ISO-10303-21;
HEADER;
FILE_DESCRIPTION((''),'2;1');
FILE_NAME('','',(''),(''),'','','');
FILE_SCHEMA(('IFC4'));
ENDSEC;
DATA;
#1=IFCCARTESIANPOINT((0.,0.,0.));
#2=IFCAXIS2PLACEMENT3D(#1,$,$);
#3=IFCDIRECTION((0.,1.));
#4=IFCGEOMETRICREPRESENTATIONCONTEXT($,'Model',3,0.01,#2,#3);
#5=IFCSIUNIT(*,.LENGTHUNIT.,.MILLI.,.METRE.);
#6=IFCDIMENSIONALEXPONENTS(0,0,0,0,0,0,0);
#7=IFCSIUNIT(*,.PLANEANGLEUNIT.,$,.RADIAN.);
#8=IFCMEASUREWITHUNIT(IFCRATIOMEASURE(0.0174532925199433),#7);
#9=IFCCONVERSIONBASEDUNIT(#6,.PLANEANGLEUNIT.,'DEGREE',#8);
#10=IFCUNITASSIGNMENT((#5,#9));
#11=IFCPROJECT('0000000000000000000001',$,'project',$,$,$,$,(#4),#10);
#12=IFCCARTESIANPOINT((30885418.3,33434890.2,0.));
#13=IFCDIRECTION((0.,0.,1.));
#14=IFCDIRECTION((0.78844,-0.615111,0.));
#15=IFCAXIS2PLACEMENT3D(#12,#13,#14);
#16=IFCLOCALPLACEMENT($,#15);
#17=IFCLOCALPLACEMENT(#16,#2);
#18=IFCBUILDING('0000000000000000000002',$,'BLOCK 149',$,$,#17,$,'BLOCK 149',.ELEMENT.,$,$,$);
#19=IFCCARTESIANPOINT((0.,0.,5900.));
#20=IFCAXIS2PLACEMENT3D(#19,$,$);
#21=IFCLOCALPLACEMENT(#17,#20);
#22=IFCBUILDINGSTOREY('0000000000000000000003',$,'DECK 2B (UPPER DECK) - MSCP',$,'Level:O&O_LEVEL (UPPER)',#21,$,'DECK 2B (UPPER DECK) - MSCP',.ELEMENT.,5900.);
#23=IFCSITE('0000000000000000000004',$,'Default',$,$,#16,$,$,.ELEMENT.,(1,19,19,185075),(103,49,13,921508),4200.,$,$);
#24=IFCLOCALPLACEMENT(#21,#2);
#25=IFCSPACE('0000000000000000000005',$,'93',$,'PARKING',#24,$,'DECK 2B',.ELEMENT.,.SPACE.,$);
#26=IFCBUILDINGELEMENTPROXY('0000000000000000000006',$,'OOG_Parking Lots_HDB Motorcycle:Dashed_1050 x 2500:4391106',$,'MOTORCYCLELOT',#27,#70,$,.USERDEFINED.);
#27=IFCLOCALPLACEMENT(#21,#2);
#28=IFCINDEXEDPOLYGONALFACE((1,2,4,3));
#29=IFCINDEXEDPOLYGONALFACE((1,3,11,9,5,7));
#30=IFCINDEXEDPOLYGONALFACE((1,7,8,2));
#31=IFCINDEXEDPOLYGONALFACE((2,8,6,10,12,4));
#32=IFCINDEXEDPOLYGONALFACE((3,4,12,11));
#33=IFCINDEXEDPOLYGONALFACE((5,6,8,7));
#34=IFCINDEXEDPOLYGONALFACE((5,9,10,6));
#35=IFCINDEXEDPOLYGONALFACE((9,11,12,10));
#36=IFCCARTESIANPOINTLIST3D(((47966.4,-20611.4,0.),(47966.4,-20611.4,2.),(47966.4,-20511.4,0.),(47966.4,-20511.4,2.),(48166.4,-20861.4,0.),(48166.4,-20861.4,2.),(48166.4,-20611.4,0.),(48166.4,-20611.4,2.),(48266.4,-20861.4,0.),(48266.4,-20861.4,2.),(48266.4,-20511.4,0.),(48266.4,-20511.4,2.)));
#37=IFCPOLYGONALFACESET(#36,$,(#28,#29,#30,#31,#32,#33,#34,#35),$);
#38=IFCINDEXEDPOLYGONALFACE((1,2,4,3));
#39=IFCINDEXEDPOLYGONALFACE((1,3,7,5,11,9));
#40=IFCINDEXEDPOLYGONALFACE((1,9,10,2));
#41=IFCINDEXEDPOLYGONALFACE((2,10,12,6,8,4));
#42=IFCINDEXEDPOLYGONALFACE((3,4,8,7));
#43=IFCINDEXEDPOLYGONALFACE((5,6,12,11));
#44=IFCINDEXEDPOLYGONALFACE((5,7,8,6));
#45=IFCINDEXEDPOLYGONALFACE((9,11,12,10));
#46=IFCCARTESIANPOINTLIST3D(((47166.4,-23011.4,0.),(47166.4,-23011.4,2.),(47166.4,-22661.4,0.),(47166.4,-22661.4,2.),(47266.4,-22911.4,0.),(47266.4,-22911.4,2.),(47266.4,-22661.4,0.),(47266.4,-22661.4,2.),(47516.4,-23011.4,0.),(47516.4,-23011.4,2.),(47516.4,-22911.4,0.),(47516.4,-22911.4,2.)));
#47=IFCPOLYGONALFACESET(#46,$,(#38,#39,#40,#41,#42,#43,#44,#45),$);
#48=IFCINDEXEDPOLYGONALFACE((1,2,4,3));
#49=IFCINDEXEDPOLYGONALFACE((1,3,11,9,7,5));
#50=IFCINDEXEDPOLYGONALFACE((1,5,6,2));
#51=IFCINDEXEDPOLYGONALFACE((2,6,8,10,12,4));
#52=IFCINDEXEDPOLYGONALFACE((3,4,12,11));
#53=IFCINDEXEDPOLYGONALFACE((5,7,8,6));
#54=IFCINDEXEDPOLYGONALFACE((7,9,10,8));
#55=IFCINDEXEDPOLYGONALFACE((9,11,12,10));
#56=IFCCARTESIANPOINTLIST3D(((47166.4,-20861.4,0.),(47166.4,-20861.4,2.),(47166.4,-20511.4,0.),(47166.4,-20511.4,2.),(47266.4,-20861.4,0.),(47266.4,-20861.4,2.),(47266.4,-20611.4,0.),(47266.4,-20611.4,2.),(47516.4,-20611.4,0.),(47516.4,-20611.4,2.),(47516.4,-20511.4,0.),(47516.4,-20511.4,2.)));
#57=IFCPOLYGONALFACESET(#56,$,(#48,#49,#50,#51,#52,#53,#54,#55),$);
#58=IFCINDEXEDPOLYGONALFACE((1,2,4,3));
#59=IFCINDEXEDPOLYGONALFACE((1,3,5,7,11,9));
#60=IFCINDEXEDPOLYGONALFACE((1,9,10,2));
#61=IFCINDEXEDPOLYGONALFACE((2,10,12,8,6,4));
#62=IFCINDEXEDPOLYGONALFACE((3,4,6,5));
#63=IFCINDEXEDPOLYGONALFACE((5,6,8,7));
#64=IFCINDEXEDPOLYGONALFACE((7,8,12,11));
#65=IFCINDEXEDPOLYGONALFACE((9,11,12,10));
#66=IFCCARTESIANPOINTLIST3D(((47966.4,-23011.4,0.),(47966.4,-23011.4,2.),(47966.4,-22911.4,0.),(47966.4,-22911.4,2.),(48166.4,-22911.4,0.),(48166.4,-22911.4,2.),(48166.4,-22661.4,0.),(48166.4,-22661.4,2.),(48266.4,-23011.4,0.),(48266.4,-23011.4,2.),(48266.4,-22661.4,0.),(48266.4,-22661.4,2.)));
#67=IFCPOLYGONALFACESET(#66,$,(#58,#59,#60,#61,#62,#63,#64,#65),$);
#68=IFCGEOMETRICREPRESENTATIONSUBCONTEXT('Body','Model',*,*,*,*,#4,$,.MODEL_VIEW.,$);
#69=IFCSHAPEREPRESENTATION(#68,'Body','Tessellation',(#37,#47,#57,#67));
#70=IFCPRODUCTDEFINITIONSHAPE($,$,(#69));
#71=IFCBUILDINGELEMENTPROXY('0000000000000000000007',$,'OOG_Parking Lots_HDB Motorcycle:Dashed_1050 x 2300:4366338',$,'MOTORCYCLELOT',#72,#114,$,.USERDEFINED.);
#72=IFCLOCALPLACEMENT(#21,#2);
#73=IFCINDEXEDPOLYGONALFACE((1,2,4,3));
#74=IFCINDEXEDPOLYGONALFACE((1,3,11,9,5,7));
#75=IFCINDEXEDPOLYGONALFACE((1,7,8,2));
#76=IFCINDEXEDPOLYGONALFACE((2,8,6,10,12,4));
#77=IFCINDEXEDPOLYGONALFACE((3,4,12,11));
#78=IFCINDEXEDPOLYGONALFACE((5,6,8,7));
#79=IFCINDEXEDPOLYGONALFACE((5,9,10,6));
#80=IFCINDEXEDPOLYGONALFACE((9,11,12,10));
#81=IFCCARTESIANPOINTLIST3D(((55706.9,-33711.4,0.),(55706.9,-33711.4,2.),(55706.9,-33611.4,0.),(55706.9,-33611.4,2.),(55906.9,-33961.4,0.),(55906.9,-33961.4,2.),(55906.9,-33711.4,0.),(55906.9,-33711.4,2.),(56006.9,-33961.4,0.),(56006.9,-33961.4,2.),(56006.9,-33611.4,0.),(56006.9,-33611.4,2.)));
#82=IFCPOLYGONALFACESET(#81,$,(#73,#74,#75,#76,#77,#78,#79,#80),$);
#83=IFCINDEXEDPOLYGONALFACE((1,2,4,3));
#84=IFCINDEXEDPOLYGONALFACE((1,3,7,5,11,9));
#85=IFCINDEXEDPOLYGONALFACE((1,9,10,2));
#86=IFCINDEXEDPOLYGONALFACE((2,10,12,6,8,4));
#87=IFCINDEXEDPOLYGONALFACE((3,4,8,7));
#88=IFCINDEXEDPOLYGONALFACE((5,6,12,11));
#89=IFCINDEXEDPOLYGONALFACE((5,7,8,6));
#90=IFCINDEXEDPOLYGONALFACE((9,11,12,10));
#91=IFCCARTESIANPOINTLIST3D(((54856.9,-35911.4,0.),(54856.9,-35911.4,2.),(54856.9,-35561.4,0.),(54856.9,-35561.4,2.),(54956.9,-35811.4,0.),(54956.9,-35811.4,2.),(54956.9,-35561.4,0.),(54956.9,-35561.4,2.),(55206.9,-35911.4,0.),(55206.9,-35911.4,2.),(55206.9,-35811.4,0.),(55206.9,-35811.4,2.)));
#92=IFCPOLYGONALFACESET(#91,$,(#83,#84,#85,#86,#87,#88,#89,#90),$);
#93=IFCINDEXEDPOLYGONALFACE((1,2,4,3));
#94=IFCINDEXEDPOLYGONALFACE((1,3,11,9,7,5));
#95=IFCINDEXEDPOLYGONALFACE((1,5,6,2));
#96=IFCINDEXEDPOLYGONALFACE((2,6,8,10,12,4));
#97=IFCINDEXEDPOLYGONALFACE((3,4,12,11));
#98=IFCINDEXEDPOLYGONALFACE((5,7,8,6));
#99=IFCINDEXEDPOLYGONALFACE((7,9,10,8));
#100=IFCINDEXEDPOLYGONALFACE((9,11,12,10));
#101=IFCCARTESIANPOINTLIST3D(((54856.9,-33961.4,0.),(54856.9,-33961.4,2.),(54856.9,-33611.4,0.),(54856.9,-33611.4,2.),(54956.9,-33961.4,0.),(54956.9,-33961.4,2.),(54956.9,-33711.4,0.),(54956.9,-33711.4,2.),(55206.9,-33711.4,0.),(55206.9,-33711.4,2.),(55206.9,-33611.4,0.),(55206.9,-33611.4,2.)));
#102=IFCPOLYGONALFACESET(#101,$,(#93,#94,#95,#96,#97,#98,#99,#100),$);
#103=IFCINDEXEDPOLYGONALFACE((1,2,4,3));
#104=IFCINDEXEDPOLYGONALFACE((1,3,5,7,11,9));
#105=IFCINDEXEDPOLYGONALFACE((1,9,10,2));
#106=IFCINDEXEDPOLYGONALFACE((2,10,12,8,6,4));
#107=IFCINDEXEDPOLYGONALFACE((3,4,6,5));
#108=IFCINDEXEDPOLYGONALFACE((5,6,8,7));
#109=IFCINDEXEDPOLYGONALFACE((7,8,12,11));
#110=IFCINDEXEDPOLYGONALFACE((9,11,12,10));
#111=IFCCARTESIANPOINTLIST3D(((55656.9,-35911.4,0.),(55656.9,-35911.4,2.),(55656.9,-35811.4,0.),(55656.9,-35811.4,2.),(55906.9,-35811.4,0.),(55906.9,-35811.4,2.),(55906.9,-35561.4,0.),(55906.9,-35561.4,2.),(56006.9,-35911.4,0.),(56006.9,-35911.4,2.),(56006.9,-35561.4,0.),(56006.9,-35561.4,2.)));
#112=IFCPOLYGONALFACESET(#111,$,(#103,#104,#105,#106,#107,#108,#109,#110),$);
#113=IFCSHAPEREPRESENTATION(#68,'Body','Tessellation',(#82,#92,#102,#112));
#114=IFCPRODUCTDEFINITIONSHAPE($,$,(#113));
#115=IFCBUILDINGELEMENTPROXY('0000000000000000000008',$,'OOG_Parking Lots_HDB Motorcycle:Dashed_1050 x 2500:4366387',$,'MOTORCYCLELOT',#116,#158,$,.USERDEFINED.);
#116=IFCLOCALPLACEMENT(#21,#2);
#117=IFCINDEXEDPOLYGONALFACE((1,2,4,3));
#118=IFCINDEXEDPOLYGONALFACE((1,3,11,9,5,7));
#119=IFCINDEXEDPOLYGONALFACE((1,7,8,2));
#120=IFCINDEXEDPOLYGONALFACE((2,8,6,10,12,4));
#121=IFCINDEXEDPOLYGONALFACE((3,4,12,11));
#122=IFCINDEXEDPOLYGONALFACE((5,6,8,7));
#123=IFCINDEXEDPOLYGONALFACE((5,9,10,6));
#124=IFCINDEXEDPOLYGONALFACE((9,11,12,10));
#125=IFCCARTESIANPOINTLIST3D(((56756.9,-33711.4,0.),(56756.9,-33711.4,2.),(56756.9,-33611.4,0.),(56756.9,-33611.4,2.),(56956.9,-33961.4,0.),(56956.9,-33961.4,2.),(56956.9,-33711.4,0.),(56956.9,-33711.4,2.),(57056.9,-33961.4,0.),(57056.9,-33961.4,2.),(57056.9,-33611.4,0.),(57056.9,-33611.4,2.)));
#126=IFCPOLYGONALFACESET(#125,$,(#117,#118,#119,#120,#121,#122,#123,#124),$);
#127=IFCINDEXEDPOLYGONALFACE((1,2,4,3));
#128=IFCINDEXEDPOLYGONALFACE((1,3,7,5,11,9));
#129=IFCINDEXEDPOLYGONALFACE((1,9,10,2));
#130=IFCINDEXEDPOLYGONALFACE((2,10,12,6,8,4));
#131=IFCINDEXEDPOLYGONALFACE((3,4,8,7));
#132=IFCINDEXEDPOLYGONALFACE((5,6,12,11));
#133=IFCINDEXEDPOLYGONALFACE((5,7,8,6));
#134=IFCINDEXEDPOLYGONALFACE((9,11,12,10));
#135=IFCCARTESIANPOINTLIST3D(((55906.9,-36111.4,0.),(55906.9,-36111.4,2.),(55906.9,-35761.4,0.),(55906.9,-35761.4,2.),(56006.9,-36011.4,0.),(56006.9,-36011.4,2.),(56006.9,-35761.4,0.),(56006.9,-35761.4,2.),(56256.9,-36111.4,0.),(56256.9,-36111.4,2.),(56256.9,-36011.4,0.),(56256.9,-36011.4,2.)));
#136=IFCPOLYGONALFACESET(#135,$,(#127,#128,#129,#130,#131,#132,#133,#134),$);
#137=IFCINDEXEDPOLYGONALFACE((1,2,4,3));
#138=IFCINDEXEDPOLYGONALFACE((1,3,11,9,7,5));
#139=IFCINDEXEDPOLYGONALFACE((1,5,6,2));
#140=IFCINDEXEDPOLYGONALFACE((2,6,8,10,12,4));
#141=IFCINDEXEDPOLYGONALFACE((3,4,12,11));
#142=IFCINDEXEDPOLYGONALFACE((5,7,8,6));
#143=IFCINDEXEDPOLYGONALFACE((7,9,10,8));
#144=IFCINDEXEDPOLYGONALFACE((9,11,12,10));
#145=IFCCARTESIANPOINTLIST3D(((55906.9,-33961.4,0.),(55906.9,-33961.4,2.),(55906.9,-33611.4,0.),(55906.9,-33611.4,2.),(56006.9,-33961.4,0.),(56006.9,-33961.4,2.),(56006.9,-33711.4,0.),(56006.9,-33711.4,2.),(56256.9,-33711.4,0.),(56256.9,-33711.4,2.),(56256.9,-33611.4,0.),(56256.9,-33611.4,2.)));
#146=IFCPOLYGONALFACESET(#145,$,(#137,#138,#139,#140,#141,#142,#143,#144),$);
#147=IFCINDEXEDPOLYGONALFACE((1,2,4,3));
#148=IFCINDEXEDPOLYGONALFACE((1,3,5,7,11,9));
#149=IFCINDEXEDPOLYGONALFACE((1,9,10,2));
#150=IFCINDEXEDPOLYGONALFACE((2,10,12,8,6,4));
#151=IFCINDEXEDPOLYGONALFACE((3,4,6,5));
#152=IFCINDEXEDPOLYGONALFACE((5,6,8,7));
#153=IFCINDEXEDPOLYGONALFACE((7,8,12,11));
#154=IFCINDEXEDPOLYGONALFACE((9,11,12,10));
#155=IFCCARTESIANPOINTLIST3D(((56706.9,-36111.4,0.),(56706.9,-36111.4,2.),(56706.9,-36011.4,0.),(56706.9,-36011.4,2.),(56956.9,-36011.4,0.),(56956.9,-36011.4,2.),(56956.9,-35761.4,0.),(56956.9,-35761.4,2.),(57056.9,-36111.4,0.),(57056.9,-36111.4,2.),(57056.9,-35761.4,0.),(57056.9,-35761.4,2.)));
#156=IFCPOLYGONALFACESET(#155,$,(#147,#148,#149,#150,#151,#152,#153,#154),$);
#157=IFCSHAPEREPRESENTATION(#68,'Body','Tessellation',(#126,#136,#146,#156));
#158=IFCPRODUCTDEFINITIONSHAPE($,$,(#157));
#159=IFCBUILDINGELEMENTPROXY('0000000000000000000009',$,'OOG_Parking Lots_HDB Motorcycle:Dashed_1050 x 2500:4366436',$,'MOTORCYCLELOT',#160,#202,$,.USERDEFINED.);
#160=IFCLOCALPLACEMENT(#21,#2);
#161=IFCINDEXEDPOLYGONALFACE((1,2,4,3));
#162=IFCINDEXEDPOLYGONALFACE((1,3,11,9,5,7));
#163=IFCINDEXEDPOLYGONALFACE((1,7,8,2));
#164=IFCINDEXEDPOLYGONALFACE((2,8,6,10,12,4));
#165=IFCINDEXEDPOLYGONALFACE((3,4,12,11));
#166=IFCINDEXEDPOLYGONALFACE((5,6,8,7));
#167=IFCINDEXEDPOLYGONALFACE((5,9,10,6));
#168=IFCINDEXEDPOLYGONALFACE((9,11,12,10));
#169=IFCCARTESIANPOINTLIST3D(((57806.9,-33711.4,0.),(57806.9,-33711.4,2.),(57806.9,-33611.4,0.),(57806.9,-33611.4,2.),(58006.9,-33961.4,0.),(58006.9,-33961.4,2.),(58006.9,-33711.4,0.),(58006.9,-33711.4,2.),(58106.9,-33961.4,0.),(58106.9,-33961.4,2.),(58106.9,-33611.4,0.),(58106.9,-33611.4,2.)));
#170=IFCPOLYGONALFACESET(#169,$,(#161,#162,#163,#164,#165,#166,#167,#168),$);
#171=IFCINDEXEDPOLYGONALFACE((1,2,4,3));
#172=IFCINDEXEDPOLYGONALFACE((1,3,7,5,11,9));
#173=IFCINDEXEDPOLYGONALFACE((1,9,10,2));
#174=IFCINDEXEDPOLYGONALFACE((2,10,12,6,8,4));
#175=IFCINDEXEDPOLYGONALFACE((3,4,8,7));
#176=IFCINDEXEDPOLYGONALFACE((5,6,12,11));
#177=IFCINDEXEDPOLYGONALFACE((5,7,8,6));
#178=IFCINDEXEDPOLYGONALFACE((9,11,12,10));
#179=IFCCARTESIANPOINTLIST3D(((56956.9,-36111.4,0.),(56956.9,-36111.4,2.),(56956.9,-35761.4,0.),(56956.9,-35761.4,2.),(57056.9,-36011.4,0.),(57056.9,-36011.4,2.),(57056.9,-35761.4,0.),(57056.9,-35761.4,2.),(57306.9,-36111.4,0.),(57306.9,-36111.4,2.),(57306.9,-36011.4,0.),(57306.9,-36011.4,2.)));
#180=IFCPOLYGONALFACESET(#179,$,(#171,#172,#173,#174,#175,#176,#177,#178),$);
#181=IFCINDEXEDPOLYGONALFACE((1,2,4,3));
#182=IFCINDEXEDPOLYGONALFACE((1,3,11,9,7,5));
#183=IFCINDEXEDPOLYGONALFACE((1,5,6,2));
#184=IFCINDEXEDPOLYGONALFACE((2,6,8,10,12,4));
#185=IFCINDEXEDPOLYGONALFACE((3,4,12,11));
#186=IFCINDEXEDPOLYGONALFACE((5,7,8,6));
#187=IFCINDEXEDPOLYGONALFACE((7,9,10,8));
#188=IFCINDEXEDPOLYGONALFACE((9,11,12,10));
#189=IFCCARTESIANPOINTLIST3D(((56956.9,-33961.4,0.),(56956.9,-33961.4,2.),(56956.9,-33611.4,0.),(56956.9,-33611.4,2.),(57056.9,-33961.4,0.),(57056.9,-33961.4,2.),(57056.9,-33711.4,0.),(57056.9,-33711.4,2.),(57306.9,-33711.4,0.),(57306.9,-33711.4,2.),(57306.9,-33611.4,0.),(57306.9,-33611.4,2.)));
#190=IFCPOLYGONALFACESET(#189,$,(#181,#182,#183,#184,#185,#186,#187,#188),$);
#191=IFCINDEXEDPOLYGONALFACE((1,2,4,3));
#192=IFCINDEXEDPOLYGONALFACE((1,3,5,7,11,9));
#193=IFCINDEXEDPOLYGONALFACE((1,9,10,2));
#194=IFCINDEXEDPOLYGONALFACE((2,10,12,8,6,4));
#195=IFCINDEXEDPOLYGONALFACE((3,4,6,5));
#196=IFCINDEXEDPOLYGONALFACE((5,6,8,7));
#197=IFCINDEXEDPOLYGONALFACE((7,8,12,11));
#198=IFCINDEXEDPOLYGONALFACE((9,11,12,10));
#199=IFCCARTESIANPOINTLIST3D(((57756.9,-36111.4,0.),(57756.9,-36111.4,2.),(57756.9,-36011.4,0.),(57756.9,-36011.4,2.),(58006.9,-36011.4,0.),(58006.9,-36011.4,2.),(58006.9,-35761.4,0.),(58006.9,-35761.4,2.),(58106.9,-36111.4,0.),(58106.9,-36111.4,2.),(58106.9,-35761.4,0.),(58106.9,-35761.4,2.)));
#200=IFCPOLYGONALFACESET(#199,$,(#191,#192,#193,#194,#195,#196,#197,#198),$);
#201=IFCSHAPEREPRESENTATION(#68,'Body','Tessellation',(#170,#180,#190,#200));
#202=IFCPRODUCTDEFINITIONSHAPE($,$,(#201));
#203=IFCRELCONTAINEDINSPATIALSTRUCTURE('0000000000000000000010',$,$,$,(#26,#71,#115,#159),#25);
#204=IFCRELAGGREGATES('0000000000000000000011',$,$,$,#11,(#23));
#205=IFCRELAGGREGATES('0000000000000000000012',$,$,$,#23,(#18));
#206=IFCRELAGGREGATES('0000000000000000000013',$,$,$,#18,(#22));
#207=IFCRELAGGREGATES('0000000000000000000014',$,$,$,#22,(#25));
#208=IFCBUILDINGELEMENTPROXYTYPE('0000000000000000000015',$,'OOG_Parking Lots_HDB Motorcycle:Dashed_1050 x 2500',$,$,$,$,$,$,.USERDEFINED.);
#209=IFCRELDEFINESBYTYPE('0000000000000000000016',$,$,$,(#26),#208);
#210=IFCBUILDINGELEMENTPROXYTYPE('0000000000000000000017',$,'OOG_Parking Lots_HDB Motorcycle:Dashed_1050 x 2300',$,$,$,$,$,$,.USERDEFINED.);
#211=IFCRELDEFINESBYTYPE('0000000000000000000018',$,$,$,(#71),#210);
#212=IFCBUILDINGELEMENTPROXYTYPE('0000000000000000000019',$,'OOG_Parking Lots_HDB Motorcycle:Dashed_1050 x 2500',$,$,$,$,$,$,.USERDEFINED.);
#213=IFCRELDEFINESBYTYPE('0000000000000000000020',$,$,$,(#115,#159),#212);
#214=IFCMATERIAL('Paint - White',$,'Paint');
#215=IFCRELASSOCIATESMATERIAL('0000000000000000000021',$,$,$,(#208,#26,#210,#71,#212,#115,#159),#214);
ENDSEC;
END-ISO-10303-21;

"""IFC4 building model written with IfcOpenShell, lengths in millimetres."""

from ifc_helpers import new_model, entity, si_unit, converted_unit, direction, frame, origin, place, context, subcontext, project, spatial, indexed_curve, outline, extrude, source, transform, mapped, material, type_object, type_shapes, element, save


model = new_model("IFC4")

# Units and contexts
model_context = context("Model", 3, precision=0.01, world=origin(), true_north=direction((0.0, 1.0)))
body_context = subcontext(model_context, "Body", "Model", "MODEL_VIEW")
ifc_project = project(units=[si_unit("LENGTHUNIT", "METRE", prefix="MILLI"), converted_unit("PLANEANGLEUNIT", "DEGREE", entity("IfcRatioMeasure", 0.0174532925199433), si_unit("PLANEANGLEUNIT", "RADIAN"), dimensions=[0, 0, 0, 0, 0, 0, 0])], contexts=[model_context])

# Site, building, storey
site_placement = place(None, frame((30885418.3, 33434890.2, 0.0), z_axis=(0.0, 0.0, 1.0), x_axis=(0.78844, -0.615111, 0.0)))
site = spatial("IfcSite", under=ifc_project, at=site_placement, Name="Default", CompositionType="ELEMENT", RefLatitude=(1, 19, 19, 185075), RefLongitude=(103, 49, 13, 921508), RefElevation=4200.0)
building_placement = place(site_placement, origin())
building = spatial("IfcBuilding", under=site, at=building_placement, Name="BLOCK 149", LongName="BLOCK 149", CompositionType="ELEMENT")
storey_placement = place(building_placement, frame((0.0, 0.0, 5900.0)))
storey = spatial("IfcBuildingStorey", under=building, at=storey_placement, Name="DECK 2B (UPPER DECK) - MSCP", ObjectType="Level:O&O_LEVEL (UPPER)", LongName="DECK 2B (UPPER DECK) - MSCP", CompositionType="ELEMENT", Elevation=5900.0)

# Shared definitions
space_placement = place(storey_placement, origin())
space = spatial("IfcSpace", under=storey, at=space_placement, Name="93", ObjectType="PARKING", LongName="DECK 2B", CompositionType="ELEMENT", PredefinedType="SPACE")

# Building element proxies
ifc_material_1 = material(Name="Paint - White", Category="Paint")
building_element_proxy_type_1 = type_object("IfcBuildingElementProxyType", Name="OOG_Parking Lots_HDB Motorcycle:Dashed_1050 x 2500", PredefinedType="USERDEFINED", material=ifc_material_1)
shared_shape_1 = source(origin(), body_context, "Body", "SweptSolid", [
    extrude(outline(indexed_curve([(-200.0, -133.3), (150.0, -133.3), (150.0, 166.7), (50.0, 166.7), (50.0, -33.3), (-200.0, -33.3), (-200.0, -133.3)], self_intersect=False)), frame((916.7, -100.0, 0.0), z_axis=(0.0, 0.0, 1.0), x_axis=(0.0, 1.0, 0.0)), (0.0, 0.0, 1.0), 2.0),
    extrude(outline(indexed_curve([(-200.0, -150.0), (150.0, -150.0), (150.0, 200.0), (50.0, 200.0), (50.0, -50.0), (-200.0, -50.0), (-200.0, -150.0)], self_intersect=False)), frame((100.0, -2300.0, 0.0), z_axis=(0.0, 0.0, 1.0), x_axis=(0.0, -1.0, 0.0)), (0.0, 0.0, 1.0), 2.0),
    extrude(outline(indexed_curve([(-200.0, -150.0), (150.0, -150.0), (150.0, 200.0), (50.0, 200.0), (50.0, -50.0), (-200.0, -50.0), (-200.0, -150.0)], self_intersect=False)), frame((100.0, -100.0, 0.0), z_axis=(0.0, 0.0, 1.0), x_axis=(-1.0, 0.0, 0.0)), (0.0, 0.0, 1.0), 2.0),
    extrude(outline(indexed_curve([(-166.7, -150.0), (133.3, -150.0), (133.3, 200.0), (33.3, 200.0), (33.3, -50.0), (-166.7, -50.0), (-166.7, -150.0)], self_intersect=False)), frame((916.7, -2300.0, 0.0)), (0.0, 0.0, 1.0), 2.0),
])
type_shapes(building_element_proxy_type_1, [shared_shape_1])
proxy_1_placement = place(space_placement, frame((47216.4, -20561.4, 0.0)))
element("IfcBuildingElementProxy", 1, at=proxy_1_placement, inside=space, type_object=building_element_proxy_type_1, material=ifc_material_1, Name="OOG_Parking Lots_HDB Motorcycle:Dashed_1050 x 2500:4391106", ObjectType="MOTORCYCLELOT", PredefinedType="USERDEFINED", context=body_context, shape_type="MappedRepresentation", body=[
    mapped(shared_shape_1, transform((0.0, 0.0, 0.0), scale=1.0)),
])
building_element_proxy_type_2 = type_object("IfcBuildingElementProxyType", Name="OOG_Parking Lots_HDB Motorcycle:Dashed_1050 x 2300", PredefinedType="USERDEFINED", material=ifc_material_1)
shared_shape_2 = source(origin(), body_context, "Body", "SweptSolid", [
    extrude(outline(indexed_curve([(-200.0, -133.3), (150.0, -133.3), (150.0, 166.7), (50.0, 166.7), (50.0, -33.3), (-200.0, -33.3), (-200.0, -133.3)], self_intersect=False)), frame((966.7, -100.0, 0.0), z_axis=(0.0, 0.0, 1.0), x_axis=(0.0, 1.0, 0.0)), (0.0, 0.0, 1.0), 2.0),
    extrude(outline(indexed_curve([(-200.0, -150.0), (150.0, -150.0), (150.0, 200.0), (50.0, 200.0), (50.0, -50.0), (-200.0, -50.0), (-200.0, -150.0)], self_intersect=False)), frame((100.0, -2100.0, 0.0), z_axis=(0.0, 0.0, 1.0), x_axis=(0.0, -1.0, 0.0)), (0.0, 0.0, 1.0), 2.0),
    extrude(outline(indexed_curve([(-200.0, -150.0), (150.0, -150.0), (150.0, 200.0), (50.0, 200.0), (50.0, -50.0), (-200.0, -50.0), (-200.0, -150.0)], self_intersect=False)), frame((100.0, -100.0, 0.0), z_axis=(0.0, 0.0, 1.0), x_axis=(-1.0, 0.0, 0.0)), (0.0, 0.0, 1.0), 2.0),
    extrude(outline(indexed_curve([(-200.0, -150.0), (150.0, -150.0), (150.0, 200.0), (50.0, 200.0), (50.0, -50.0), (-200.0, -50.0), (-200.0, -150.0)], self_intersect=False)), frame((950.0, -2100.0, 0.0)), (0.0, 0.0, 1.0), 2.0),
])
type_shapes(building_element_proxy_type_2, [shared_shape_2])
proxy_2_placement = place(space_placement, frame((54906.9, -33661.4, 0.0)))
element("IfcBuildingElementProxy", 2, at=proxy_2_placement, inside=space, type_object=building_element_proxy_type_2, material=ifc_material_1, Name="OOG_Parking Lots_HDB Motorcycle:Dashed_1050 x 2300:4366338", ObjectType="MOTORCYCLELOT", PredefinedType="USERDEFINED", context=body_context, shape_type="MappedRepresentation", body=[
    mapped(shared_shape_2, transform((0.0, 0.0, 0.0), scale=1.0)),
])
building_element_proxy_type_3 = type_object("IfcBuildingElementProxyType", Name="OOG_Parking Lots_HDB Motorcycle:Dashed_1050 x 2500", PredefinedType="USERDEFINED", material=ifc_material_1)
shared_shape_3 = source(origin(), body_context, "Body", "SweptSolid", [
    extrude(outline(indexed_curve([(-200.0, -133.3), (150.0, -133.3), (150.0, 166.7), (50.0, 166.7), (50.0, -33.3), (-200.0, -33.3), (-200.0, -133.3)], self_intersect=False)), frame((966.7, -100.0, 0.0), z_axis=(0.0, 0.0, 1.0), x_axis=(0.0, 1.0, 0.0)), (0.0, 0.0, 1.0), 2.0),
    extrude(outline(indexed_curve([(-200.0, -150.0), (150.0, -150.0), (150.0, 200.0), (50.0, 200.0), (50.0, -50.0), (-200.0, -50.0), (-200.0, -150.0)], self_intersect=False)), frame((100.0, -2300.0, 0.0), z_axis=(0.0, 0.0, 1.0), x_axis=(0.0, -1.0, 0.0)), (0.0, 0.0, 1.0), 2.0),
    extrude(outline(indexed_curve([(-200.0, -150.0), (150.0, -150.0), (150.0, 200.0), (50.0, 200.0), (50.0, -50.0), (-200.0, -50.0), (-200.0, -150.0)], self_intersect=False)), frame((100.0, -100.0, 0.0), z_axis=(0.0, 0.0, 1.0), x_axis=(-1.0, 0.0, 0.0)), (0.0, 0.0, 1.0), 2.0),
    extrude(outline(indexed_curve([(-200.0, -150.0), (150.0, -150.0), (150.0, 200.0), (50.0, 200.0), (50.0, -50.0), (-200.0, -50.0), (-200.0, -150.0)], self_intersect=False)), frame((950.0, -2300.0, 0.0)), (0.0, 0.0, 1.0), 2.0),
])
type_shapes(building_element_proxy_type_3, [shared_shape_3])
for number, where, name in (
    (3, (55956.9, -33661.4, 0.0), "OOG_Parking Lots_HDB Motorcycle:Dashed_1050 x 2500:4366387"),
    (4, (57006.9, -33661.4, 0.0), "OOG_Parking Lots_HDB Motorcycle:Dashed_1050 x 2500:4366436"),
):
    element("IfcBuildingElementProxy", number, at=place(space_placement, frame(where)), inside=space, type_object=building_element_proxy_type_3, material=ifc_material_1, Name=name, ObjectType="MOTORCYCLELOT", PredefinedType="USERDEFINED", context=body_context, shape_type="MappedRepresentation", body=[
        mapped(shared_shape_3, transform((0.0, 0.0, 0.0), scale=1.0)),
    ])

save(model, "model.ifc")
